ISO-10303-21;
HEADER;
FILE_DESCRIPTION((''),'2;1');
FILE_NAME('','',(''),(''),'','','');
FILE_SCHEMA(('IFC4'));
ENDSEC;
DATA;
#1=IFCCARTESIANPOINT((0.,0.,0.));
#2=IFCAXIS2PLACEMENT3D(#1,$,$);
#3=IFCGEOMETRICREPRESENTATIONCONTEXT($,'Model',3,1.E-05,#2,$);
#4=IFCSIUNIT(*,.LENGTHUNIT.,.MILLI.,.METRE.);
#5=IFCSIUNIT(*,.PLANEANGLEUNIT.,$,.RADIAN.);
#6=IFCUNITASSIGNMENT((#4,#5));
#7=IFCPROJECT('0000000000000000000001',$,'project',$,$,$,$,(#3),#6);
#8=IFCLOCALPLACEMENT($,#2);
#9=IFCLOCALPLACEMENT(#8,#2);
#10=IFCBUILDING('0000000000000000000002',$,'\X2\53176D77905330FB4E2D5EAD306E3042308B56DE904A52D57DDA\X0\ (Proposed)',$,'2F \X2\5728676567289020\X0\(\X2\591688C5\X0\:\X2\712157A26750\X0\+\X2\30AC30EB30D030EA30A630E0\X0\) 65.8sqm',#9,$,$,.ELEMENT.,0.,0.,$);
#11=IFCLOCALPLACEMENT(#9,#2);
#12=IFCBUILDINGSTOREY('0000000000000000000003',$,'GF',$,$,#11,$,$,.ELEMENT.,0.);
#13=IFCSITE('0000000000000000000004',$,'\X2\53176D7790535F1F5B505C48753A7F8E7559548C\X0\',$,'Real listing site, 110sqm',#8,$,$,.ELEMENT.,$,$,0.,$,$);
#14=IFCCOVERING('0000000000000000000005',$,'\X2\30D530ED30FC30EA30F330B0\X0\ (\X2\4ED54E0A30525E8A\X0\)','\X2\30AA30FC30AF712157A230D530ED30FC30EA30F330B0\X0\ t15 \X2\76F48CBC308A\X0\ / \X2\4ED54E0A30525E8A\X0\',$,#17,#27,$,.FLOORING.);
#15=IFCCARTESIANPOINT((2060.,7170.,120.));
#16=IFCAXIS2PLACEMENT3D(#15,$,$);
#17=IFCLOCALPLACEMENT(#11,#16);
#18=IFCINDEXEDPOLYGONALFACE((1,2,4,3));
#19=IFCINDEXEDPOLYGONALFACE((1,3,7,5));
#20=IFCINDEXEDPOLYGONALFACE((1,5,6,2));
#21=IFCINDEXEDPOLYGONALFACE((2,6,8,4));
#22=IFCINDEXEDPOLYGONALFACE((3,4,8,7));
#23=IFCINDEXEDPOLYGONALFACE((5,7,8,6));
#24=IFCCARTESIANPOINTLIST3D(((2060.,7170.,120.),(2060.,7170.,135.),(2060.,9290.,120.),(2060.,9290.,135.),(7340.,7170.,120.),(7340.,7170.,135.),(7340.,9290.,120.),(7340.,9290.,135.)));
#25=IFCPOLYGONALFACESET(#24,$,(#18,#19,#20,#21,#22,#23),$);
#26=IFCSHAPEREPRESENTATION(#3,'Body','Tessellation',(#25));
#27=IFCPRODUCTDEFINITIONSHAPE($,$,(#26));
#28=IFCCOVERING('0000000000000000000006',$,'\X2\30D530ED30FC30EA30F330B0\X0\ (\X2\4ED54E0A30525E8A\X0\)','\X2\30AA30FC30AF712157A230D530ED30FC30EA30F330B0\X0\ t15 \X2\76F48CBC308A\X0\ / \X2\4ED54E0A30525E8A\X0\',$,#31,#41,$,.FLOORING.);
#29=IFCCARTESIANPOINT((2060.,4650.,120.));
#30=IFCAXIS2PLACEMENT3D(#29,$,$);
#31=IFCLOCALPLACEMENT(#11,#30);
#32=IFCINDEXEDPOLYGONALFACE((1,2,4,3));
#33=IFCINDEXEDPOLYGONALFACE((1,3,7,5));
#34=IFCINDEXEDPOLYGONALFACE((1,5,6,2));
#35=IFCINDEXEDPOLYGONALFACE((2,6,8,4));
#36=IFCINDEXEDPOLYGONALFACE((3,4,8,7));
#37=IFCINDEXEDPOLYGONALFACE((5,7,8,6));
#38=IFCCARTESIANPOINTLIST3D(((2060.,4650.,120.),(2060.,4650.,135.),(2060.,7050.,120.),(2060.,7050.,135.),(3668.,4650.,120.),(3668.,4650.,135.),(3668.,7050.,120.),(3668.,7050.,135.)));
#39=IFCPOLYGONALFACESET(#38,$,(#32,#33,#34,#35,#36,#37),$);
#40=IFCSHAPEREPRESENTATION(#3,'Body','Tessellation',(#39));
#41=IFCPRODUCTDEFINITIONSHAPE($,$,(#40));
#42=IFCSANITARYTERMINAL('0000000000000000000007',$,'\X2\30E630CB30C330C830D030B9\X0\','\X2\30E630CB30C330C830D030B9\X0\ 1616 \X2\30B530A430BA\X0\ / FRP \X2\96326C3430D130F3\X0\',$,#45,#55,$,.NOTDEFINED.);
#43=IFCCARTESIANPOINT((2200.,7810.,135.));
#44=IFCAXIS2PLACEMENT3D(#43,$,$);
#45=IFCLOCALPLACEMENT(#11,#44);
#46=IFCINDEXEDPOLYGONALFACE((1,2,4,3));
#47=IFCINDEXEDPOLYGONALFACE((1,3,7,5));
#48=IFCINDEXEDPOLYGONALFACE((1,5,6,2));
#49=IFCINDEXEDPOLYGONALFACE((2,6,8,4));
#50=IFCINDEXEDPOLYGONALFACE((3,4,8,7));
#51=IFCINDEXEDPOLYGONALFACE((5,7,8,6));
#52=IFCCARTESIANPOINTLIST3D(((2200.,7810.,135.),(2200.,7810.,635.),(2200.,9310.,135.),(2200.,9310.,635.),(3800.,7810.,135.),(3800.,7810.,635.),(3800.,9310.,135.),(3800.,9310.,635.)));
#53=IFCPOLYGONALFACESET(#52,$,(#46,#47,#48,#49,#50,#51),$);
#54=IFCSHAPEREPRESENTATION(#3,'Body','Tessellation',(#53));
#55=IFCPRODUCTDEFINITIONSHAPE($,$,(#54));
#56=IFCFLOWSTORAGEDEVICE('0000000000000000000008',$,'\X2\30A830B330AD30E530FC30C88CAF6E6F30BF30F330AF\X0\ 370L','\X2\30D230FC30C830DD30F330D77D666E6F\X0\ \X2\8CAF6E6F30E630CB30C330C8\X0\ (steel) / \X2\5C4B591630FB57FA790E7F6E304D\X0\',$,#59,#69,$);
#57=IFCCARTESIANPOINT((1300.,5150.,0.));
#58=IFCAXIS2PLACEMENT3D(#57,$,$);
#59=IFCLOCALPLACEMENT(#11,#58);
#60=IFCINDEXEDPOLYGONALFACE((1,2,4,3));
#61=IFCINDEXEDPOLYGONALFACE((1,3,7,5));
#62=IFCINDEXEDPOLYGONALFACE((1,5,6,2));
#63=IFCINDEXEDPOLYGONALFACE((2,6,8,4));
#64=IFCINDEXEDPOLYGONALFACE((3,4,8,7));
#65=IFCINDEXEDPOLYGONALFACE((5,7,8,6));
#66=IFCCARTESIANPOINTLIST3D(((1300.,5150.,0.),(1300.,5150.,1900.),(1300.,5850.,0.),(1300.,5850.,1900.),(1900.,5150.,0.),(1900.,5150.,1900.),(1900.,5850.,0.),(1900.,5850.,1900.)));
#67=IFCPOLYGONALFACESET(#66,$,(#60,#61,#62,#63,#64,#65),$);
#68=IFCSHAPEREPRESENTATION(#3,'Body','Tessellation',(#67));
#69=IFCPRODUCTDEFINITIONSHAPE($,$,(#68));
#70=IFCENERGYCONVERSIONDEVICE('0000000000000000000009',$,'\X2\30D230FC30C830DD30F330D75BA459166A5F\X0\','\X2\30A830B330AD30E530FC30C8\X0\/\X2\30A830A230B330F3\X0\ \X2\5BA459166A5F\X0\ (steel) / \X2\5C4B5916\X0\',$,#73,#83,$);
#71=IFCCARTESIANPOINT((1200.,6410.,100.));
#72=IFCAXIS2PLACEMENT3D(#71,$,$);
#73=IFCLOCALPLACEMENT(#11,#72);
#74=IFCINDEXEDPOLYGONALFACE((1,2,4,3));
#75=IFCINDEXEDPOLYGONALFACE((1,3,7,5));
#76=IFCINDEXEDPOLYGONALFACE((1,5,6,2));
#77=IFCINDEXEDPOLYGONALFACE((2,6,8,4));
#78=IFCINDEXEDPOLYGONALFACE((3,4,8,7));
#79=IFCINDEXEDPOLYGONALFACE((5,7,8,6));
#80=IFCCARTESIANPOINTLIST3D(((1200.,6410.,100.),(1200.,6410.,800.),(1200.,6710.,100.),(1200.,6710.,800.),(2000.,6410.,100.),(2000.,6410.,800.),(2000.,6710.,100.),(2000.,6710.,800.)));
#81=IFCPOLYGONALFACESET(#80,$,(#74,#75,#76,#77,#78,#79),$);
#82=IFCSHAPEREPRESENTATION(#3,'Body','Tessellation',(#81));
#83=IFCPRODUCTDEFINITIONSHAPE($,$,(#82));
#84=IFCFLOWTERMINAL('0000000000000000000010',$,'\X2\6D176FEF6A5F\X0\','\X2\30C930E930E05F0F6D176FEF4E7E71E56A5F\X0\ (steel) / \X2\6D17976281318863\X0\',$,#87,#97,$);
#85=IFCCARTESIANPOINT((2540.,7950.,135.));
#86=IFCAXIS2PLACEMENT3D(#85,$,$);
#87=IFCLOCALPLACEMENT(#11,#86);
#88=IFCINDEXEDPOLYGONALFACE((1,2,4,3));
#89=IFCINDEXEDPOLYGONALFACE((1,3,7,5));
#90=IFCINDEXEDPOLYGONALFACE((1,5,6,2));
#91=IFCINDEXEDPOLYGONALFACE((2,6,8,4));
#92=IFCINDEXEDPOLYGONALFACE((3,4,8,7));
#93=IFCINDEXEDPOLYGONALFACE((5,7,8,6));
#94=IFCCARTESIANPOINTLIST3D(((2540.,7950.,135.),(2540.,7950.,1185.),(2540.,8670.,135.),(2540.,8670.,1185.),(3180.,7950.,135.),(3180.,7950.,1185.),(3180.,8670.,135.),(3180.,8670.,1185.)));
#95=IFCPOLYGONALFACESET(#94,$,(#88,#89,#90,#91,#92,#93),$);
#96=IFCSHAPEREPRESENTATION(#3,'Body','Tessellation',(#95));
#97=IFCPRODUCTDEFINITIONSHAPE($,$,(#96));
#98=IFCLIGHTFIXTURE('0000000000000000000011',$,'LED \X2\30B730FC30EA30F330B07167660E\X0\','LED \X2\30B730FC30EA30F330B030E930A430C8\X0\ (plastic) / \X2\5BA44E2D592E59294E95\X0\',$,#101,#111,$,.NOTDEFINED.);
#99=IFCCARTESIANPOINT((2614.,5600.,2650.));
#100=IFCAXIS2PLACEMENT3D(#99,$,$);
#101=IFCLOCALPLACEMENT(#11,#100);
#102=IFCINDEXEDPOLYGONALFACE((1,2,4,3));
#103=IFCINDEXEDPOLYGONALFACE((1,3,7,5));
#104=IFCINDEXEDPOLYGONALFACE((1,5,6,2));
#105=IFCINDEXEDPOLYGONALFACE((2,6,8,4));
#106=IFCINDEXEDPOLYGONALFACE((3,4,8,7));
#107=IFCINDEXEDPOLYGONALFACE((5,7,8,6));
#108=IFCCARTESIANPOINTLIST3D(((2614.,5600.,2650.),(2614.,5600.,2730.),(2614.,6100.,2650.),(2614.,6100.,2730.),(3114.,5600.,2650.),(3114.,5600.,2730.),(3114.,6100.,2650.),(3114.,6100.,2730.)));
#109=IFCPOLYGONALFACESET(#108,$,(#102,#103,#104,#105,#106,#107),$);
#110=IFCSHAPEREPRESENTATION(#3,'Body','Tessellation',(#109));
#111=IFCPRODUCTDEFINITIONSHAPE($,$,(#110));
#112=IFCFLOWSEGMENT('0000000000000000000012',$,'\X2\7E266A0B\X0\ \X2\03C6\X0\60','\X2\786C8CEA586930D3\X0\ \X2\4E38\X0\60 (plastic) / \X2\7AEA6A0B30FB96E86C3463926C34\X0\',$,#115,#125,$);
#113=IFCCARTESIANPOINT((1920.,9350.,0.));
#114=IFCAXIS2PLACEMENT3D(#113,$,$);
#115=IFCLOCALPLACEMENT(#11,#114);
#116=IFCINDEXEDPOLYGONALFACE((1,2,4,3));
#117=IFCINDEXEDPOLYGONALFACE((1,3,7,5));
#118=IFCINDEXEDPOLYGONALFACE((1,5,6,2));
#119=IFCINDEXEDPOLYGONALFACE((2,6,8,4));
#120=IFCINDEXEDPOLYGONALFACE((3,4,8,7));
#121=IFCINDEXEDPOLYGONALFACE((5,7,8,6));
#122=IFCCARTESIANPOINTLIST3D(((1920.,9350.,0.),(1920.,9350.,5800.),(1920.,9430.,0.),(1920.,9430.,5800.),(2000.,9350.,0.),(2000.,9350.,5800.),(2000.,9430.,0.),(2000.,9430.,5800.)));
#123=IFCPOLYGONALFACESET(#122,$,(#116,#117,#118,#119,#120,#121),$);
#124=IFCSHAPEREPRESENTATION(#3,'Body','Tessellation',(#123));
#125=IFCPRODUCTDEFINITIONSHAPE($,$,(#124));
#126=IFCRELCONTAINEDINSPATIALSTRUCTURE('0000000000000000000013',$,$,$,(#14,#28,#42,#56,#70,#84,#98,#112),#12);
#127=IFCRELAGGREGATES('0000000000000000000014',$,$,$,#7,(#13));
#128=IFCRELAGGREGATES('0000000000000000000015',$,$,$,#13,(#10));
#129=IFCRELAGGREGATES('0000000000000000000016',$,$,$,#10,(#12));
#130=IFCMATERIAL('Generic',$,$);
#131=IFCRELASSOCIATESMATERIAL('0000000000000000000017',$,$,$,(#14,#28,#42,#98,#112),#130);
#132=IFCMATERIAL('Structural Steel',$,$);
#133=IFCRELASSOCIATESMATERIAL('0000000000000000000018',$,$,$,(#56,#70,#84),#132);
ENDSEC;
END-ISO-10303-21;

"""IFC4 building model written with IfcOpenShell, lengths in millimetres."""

from ifc_helpers import new_model, si_unit, frame, frame_2d, origin, place, context, project, spatial, rectangle, extrude, material, element, save


model = new_model("IFC4")

# Units and contexts
model_context = context("Model", 3, precision=1e-05, world=origin())
ifc_project = project(units=[si_unit("LENGTHUNIT", "METRE", prefix="MILLI"), si_unit("PLANEANGLEUNIT", "RADIAN")], contexts=[model_context])

# Site, building, storey
site_placement = place(None, origin())
site = spatial("IfcSite", under=ifc_project, at=site_placement, Name="北海道弟子屈町美留和", ObjectType="Real listing site, 110sqm", CompositionType="ELEMENT", RefElevation=0.0)
building_placement = place(site_placement, origin())
building = spatial("IfcBuilding", under=site, at=building_placement, Name="北海道・中庭のある回遊動線 (Proposed)", ObjectType="2F 在来木造(外装:無垢材+ガルバリウム) 65.8sqm", CompositionType="ELEMENT", ElevationOfRefHeight=0.0, ElevationOfTerrain=0.0)
storey_placement = place(building_placement, origin())
storey = spatial("IfcBuildingStorey", under=building, at=storey_placement, Name="GF", CompositionType="ELEMENT", Elevation=0.0)

# Coverings
ifc_material_1 = material(Name="Generic")
covering_1_placement = place(storey_placement, frame((2060.0, 7170.0, 120.0)))
element("IfcCovering", 1, at=covering_1_placement, inside=storey, material=ifc_material_1, Name="フローリング (仕上げ床)", Description="オーク無垢フローリング t15 直貼り / 仕上げ床", PredefinedType="FLOORING", context=model_context, shape_type="SweptSolid", body=[
    extrude(rectangle(XDim=5280.0, YDim=2120.0, at=frame_2d((2640.0, 1060.0))), frame((2060.0, 7170.0, 120.0)), (0.0, 0.0, 1.0), 15.0),
])
covering_2_placement = place(storey_placement, frame((2060.0, 4650.0, 120.0)))
element("IfcCovering", 2, at=covering_2_placement, inside=storey, material=ifc_material_1, Name="フローリング (仕上げ床)", Description="オーク無垢フローリング t15 直貼り / 仕上げ床", PredefinedType="FLOORING", context=model_context, shape_type="SweptSolid", body=[
    extrude(rectangle(XDim=1608.0, YDim=2400.0, at=frame_2d((804.0, 1200.0))), frame((2060.0, 4650.0, 120.0)), (0.0, 0.0, 1.0), 15.0),
])

# Sanitary terminal
sanitary_terminal_placement = place(storey_placement, frame((2200.0, 7810.0, 135.0)))
element("IfcSanitaryTerminal", 3, at=sanitary_terminal_placement, inside=storey, material=ifc_material_1, Name="ユニットバス", Description="ユニットバス 1616 サイズ / FRP 防水パン", PredefinedType="NOTDEFINED", context=model_context, shape_type="SweptSolid", body=[
    extrude(rectangle(XDim=1600.0, YDim=1500.0, at=frame_2d((800.0, 750.0))), frame((2200.0, 7810.0, 135.0)), (0.0, 0.0, 1.0), 500.0),
])

# Flow storage device
ifc_material_2 = material(Name="Structural Steel")
flow_storage_device_placement = place(storey_placement, frame((1300.0, 5150.0, 0.0)))
element("IfcFlowStorageDevice", 4, at=flow_storage_device_placement, inside=storey, material=ifc_material_2, Name="エコキュート貯湯タンク 370L", Description="ヒートポンプ給湯 貯湯ユニット (steel) / 屋外・基礎置き", context=model_context, shape_type="SweptSolid", body=[
    extrude(rectangle(XDim=600.0, YDim=700.0, at=frame_2d((300.0, 350.0))), frame((1300.0, 5150.0, 0.0)), (0.0, 0.0, 1.0), 1900.0),
])

# Energy conversion device
energy_conversion_device_placement = place(storey_placement, frame((1200.0, 6410.0, 100.0)))
element("IfcEnergyConversionDevice", 5, at=energy_conversion_device_placement, inside=storey, material=ifc_material_2, Name="ヒートポンプ室外機", Description="エコキュート/エアコン 室外機 (steel) / 屋外", context=model_context, shape_type="SweptSolid", body=[
    extrude(rectangle(XDim=800.0, YDim=300.0, at=frame_2d((400.0, 150.0))), frame((1200.0, 6410.0, 100.0)), (0.0, 0.0, 1.0), 700.0),
])

# Flow terminal
flow_terminal_placement = place(storey_placement, frame((2540.0, 7950.0, 135.0)))
element("IfcFlowTerminal", 6, at=flow_terminal_placement, inside=storey, material=ifc_material_2, Name="洗濯機", Description="ドラム式洗濯乾燥機 (steel) / 洗面脱衣", context=model_context, shape_type="SweptSolid", body=[
    extrude(rectangle(XDim=640.0, YDim=720.0, at=frame_2d((320.0, 360.0))), frame((2540.0, 7950.0, 135.0)), (0.0, 0.0, 1.0), 1050.0),
])

# Light fixture
light_fixture_placement = place(storey_placement, frame((2614.0, 5600.0, 2650.0)))
element("IfcLightFixture", 7, at=light_fixture_placement, inside=storey, material=ifc_material_1, Name="LED シーリング照明", Description="LED シーリングライト (plastic) / 室中央天井", PredefinedType="NOTDEFINED", context=model_context, shape_type="SweptSolid", body=[
    extrude(rectangle(XDim=500.0, YDim=500.0, at=frame_2d((250.0, 250.0))), frame((2614.0, 5600.0, 2650.0)), (0.0, 0.0, 1.0), 80.0),
])

# Flow segment
flow_segment_placement = place(storey_placement, frame((1920.0, 9350.0, 0.0)))
element("IfcFlowSegment", 8, at=flow_segment_placement, inside=storey, material=ifc_material_1, Name="縦樋 φ60", Description="硬質塩ビ 丸60 (plastic) / 竪樋・雨水排水", context=model_context, shape_type="SweptSolid", body=[
    extrude(rectangle(XDim=80.0, YDim=80.0, at=frame_2d((40.0, 40.0))), frame((1920.0, 9350.0, 0.0)), (0.0, 0.0, 1.0), 5800.0),
])

save(model, "model.ifc")
